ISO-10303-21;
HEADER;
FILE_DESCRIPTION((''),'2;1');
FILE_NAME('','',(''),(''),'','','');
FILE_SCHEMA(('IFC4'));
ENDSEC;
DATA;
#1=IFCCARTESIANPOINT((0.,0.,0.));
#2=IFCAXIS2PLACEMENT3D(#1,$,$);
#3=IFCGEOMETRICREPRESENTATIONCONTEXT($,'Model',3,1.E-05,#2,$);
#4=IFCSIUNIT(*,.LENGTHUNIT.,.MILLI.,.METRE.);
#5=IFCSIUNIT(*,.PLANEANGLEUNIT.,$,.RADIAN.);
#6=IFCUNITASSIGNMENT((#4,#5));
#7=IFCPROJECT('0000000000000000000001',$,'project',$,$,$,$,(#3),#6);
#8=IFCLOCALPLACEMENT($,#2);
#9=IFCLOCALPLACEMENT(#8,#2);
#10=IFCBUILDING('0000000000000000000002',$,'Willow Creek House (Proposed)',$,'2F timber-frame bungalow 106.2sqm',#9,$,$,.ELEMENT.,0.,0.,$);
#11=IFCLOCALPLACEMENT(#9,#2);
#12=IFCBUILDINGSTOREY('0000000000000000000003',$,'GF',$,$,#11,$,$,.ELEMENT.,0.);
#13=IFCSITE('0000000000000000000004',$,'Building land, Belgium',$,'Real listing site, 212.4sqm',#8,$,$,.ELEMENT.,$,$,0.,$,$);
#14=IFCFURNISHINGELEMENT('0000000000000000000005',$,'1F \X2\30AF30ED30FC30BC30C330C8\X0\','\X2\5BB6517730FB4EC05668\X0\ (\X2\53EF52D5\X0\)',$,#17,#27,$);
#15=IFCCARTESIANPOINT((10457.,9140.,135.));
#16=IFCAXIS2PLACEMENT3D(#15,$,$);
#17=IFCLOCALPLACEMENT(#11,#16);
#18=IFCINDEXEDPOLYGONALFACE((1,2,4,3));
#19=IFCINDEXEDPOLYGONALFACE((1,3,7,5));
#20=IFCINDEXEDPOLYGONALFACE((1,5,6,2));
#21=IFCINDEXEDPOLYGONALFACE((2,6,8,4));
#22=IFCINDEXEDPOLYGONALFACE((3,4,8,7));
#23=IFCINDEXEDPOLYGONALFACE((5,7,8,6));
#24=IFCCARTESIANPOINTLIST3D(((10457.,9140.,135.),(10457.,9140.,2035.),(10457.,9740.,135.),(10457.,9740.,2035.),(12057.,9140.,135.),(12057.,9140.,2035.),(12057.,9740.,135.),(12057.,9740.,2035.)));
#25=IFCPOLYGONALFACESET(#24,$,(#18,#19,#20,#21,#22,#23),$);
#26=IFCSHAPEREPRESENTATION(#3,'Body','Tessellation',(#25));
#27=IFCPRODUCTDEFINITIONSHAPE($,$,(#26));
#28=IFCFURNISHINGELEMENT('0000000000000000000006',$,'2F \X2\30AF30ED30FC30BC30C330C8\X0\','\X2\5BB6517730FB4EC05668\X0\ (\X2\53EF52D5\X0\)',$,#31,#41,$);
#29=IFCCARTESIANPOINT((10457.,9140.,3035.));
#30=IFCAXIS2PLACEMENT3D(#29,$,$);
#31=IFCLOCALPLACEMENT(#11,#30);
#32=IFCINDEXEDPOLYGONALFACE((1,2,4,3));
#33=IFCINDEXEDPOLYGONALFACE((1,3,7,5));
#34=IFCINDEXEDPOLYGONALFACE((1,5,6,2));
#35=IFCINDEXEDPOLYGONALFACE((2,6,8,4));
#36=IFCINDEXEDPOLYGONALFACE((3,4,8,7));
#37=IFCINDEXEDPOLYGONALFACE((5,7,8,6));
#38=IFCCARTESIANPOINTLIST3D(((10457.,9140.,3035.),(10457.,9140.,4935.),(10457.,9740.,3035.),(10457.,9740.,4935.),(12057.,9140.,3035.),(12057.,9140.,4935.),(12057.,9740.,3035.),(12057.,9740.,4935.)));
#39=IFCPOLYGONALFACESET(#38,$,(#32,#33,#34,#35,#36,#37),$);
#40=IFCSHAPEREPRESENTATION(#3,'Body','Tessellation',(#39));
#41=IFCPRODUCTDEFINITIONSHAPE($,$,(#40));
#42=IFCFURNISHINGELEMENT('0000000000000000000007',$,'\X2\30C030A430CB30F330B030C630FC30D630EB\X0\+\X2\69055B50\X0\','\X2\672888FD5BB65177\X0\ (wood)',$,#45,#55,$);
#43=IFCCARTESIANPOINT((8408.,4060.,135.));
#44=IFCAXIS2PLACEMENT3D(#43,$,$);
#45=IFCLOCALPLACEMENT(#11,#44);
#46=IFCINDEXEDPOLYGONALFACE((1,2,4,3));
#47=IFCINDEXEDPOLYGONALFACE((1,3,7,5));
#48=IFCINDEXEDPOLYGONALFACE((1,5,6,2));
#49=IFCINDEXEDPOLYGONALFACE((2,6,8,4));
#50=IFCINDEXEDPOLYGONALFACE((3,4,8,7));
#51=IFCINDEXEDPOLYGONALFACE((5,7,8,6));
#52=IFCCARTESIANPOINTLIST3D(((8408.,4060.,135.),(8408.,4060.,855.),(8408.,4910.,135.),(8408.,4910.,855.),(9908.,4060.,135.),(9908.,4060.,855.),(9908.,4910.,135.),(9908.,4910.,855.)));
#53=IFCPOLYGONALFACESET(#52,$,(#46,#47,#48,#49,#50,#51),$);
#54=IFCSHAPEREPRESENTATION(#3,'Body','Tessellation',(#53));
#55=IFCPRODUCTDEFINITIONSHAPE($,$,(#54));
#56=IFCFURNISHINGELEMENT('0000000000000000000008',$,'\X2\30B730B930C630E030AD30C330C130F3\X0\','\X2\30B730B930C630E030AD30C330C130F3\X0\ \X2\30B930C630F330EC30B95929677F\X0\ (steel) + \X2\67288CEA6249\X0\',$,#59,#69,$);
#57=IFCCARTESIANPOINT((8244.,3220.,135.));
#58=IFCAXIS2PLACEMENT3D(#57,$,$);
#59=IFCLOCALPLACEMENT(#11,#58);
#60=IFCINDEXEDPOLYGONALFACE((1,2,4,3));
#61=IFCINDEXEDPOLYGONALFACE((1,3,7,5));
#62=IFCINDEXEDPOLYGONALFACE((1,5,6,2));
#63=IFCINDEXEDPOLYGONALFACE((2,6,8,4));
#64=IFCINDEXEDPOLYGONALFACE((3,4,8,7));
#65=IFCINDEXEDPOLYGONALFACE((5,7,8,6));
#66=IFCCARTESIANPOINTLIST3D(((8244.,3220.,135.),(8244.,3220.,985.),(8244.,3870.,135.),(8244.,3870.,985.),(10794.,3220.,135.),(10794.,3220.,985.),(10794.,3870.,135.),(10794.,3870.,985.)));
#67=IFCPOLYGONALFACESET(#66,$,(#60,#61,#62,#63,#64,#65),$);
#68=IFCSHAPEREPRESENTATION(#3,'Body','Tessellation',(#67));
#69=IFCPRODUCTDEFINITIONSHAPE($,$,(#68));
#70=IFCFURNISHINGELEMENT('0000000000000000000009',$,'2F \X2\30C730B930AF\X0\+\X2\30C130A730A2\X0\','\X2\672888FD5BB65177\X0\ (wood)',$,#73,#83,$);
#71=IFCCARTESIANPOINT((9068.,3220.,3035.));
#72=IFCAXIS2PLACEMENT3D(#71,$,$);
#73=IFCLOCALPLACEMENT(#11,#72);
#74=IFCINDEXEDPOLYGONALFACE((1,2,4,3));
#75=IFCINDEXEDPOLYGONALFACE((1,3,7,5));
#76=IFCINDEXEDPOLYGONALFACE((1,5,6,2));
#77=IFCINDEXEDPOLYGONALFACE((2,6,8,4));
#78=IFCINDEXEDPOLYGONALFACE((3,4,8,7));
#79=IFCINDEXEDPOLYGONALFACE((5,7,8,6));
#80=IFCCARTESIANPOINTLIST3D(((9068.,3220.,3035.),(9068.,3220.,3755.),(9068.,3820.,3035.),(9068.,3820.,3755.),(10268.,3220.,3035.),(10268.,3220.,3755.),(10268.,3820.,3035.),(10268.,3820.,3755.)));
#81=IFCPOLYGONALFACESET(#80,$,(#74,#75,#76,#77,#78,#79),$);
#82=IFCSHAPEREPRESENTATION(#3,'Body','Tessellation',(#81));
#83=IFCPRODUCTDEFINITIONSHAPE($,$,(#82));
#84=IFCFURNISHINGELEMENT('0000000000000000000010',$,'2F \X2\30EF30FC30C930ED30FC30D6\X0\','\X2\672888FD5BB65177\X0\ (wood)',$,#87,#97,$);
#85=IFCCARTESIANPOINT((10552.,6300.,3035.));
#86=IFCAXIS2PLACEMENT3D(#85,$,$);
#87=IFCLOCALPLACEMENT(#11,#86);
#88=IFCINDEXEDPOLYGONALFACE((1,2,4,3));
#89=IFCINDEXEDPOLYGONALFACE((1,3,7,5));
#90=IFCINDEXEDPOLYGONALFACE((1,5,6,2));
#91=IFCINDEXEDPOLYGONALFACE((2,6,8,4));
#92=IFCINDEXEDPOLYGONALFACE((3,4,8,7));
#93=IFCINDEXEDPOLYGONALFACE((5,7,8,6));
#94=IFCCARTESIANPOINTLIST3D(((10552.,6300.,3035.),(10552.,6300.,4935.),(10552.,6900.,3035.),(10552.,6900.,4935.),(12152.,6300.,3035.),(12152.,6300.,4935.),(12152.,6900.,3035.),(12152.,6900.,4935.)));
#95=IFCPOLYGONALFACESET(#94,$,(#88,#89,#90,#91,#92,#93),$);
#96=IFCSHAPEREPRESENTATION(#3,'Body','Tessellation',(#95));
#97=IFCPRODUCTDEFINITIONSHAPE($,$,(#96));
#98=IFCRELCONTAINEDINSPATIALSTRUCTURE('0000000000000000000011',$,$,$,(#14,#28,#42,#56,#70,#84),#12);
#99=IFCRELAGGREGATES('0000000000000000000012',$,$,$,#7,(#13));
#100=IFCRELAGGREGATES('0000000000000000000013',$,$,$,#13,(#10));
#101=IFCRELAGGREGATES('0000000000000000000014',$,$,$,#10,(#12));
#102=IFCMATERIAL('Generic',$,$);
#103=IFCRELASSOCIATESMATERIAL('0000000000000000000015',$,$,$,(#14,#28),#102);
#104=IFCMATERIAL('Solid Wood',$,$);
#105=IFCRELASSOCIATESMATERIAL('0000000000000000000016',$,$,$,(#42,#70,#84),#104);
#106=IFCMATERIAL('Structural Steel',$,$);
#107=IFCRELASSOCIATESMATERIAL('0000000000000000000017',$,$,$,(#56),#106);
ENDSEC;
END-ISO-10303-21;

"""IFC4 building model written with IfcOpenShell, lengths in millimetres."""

from ifc_helpers import new_model, si_unit, frame, frame_2d, origin, place, context, project, spatial, rectangle, extrude, material, element, save


model = new_model("IFC4")

# Units and contexts
model_context = context("Model", 3, precision=1e-05, world=origin())
ifc_project = project(units=[si_unit("LENGTHUNIT", "METRE", prefix="MILLI"), si_unit("PLANEANGLEUNIT", "RADIAN")], contexts=[model_context])

# Site, building, storey
site_placement = place(None, origin())
site = spatial("IfcSite", under=ifc_project, at=site_placement, Name="Building land, Belgium", ObjectType="Real listing site, 212.4sqm", CompositionType="ELEMENT", RefElevation=0.0)
building_placement = place(site_placement, origin())
building = spatial("IfcBuilding", under=site, at=building_placement, Name="Willow Creek House (Proposed)", ObjectType="2F timber-frame bungalow 106.2sqm", CompositionType="ELEMENT", ElevationOfRefHeight=0.0, ElevationOfTerrain=0.0)
storey_placement = place(building_placement, origin())
storey = spatial("IfcBuildingStorey", under=building, at=storey_placement, Name="GF", CompositionType="ELEMENT", Elevation=0.0)

# Shared definitions
ifc_material_1 = material(Name="Solid Wood")

# Shared definitions
ifc_material_2 = material(Name="Generic")

# Furnishing elements
furnishing_1_placement = place(storey_placement, frame((10457.0, 9140.0, 135.0)))
element("IfcFurnishingElement", 1, at=furnishing_1_placement, inside=storey, material=ifc_material_2, Name="1F クローゼット", Description="家具・什器 (可動)", context=model_context, shape_type="SweptSolid", body=[
    extrude(rectangle(XDim=1600.0, YDim=600.0, at=frame_2d((800.0, 300.0))), frame((10457.0, 9140.0, 135.0)), (0.0, 0.0, 1.0), 1900.0),
])
furnishing_2_placement = place(storey_placement, frame((10457.0, 9140.0, 3035.0)))
element("IfcFurnishingElement", 2, at=furnishing_2_placement, inside=storey, material=ifc_material_2, Name="2F クローゼット", Description="家具・什器 (可動)", context=model_context, shape_type="SweptSolid", body=[
    extrude(rectangle(XDim=1600.0, YDim=600.0, at=frame_2d((800.0, 300.0))), frame((10457.0, 9140.0, 3035.0)), (0.0, 0.0, 1.0), 1900.0),
])
furnishing_3_placement = place(storey_placement, frame((8408.0, 4060.0, 135.0)))
element("IfcFurnishingElement", 3, at=furnishing_3_placement, inside=storey, material=ifc_material_1, Name="ダイニングテーブル+椅子", Description="木製家具 (wood)", context=model_context, shape_type="SweptSolid", body=[
    extrude(rectangle(XDim=1500.0, YDim=850.0, at=frame_2d((750.0, 425.0))), frame((8408.0, 4060.0, 135.0)), (0.0, 0.0, 1.0), 720.0),
])
ifc_material_3 = material(Name="Structural Steel")
furnishing_4_placement = place(storey_placement, frame((8244.0, 3220.0, 135.0)))
element("IfcFurnishingElement", 4, at=furnishing_4_placement, inside=storey, material=ifc_material_3, Name="システムキッチン", Description="システムキッチン ステンレス天板 (steel) + 木質扉", context=model_context, shape_type="SweptSolid", body=[
    extrude(rectangle(XDim=2550.0, YDim=650.0, at=frame_2d((1275.0, 325.0))), frame((8244.0, 3220.0, 135.0)), (0.0, 0.0, 1.0), 850.0),
])
furnishing_5_placement = place(storey_placement, frame((9068.0, 3220.0, 3035.0)))
element("IfcFurnishingElement", 5, at=furnishing_5_placement, inside=storey, material=ifc_material_1, Name="2F デスク+チェア", Description="木製家具 (wood)", context=model_context, shape_type="SweptSolid", body=[
    extrude(rectangle(XDim=1200.0, YDim=600.0, at=frame_2d((600.0, 300.0))), frame((9068.0, 3220.0, 3035.0)), (0.0, 0.0, 1.0), 720.0),
])
furnishing_6_placement = place(storey_placement, frame((10552.0, 6300.0, 3035.0)))
element("IfcFurnishingElement", 6, at=furnishing_6_placement, inside=storey, material=ifc_material_1, Name="2F ワードローブ", Description="木製家具 (wood)", context=model_context, shape_type="SweptSolid", body=[
    extrude(rectangle(XDim=1600.0, YDim=600.0, at=frame_2d((800.0, 300.0))), frame((10552.0, 6300.0, 3035.0)), (0.0, 0.0, 1.0), 1900.0),
])

save(model, "model.ifc")
